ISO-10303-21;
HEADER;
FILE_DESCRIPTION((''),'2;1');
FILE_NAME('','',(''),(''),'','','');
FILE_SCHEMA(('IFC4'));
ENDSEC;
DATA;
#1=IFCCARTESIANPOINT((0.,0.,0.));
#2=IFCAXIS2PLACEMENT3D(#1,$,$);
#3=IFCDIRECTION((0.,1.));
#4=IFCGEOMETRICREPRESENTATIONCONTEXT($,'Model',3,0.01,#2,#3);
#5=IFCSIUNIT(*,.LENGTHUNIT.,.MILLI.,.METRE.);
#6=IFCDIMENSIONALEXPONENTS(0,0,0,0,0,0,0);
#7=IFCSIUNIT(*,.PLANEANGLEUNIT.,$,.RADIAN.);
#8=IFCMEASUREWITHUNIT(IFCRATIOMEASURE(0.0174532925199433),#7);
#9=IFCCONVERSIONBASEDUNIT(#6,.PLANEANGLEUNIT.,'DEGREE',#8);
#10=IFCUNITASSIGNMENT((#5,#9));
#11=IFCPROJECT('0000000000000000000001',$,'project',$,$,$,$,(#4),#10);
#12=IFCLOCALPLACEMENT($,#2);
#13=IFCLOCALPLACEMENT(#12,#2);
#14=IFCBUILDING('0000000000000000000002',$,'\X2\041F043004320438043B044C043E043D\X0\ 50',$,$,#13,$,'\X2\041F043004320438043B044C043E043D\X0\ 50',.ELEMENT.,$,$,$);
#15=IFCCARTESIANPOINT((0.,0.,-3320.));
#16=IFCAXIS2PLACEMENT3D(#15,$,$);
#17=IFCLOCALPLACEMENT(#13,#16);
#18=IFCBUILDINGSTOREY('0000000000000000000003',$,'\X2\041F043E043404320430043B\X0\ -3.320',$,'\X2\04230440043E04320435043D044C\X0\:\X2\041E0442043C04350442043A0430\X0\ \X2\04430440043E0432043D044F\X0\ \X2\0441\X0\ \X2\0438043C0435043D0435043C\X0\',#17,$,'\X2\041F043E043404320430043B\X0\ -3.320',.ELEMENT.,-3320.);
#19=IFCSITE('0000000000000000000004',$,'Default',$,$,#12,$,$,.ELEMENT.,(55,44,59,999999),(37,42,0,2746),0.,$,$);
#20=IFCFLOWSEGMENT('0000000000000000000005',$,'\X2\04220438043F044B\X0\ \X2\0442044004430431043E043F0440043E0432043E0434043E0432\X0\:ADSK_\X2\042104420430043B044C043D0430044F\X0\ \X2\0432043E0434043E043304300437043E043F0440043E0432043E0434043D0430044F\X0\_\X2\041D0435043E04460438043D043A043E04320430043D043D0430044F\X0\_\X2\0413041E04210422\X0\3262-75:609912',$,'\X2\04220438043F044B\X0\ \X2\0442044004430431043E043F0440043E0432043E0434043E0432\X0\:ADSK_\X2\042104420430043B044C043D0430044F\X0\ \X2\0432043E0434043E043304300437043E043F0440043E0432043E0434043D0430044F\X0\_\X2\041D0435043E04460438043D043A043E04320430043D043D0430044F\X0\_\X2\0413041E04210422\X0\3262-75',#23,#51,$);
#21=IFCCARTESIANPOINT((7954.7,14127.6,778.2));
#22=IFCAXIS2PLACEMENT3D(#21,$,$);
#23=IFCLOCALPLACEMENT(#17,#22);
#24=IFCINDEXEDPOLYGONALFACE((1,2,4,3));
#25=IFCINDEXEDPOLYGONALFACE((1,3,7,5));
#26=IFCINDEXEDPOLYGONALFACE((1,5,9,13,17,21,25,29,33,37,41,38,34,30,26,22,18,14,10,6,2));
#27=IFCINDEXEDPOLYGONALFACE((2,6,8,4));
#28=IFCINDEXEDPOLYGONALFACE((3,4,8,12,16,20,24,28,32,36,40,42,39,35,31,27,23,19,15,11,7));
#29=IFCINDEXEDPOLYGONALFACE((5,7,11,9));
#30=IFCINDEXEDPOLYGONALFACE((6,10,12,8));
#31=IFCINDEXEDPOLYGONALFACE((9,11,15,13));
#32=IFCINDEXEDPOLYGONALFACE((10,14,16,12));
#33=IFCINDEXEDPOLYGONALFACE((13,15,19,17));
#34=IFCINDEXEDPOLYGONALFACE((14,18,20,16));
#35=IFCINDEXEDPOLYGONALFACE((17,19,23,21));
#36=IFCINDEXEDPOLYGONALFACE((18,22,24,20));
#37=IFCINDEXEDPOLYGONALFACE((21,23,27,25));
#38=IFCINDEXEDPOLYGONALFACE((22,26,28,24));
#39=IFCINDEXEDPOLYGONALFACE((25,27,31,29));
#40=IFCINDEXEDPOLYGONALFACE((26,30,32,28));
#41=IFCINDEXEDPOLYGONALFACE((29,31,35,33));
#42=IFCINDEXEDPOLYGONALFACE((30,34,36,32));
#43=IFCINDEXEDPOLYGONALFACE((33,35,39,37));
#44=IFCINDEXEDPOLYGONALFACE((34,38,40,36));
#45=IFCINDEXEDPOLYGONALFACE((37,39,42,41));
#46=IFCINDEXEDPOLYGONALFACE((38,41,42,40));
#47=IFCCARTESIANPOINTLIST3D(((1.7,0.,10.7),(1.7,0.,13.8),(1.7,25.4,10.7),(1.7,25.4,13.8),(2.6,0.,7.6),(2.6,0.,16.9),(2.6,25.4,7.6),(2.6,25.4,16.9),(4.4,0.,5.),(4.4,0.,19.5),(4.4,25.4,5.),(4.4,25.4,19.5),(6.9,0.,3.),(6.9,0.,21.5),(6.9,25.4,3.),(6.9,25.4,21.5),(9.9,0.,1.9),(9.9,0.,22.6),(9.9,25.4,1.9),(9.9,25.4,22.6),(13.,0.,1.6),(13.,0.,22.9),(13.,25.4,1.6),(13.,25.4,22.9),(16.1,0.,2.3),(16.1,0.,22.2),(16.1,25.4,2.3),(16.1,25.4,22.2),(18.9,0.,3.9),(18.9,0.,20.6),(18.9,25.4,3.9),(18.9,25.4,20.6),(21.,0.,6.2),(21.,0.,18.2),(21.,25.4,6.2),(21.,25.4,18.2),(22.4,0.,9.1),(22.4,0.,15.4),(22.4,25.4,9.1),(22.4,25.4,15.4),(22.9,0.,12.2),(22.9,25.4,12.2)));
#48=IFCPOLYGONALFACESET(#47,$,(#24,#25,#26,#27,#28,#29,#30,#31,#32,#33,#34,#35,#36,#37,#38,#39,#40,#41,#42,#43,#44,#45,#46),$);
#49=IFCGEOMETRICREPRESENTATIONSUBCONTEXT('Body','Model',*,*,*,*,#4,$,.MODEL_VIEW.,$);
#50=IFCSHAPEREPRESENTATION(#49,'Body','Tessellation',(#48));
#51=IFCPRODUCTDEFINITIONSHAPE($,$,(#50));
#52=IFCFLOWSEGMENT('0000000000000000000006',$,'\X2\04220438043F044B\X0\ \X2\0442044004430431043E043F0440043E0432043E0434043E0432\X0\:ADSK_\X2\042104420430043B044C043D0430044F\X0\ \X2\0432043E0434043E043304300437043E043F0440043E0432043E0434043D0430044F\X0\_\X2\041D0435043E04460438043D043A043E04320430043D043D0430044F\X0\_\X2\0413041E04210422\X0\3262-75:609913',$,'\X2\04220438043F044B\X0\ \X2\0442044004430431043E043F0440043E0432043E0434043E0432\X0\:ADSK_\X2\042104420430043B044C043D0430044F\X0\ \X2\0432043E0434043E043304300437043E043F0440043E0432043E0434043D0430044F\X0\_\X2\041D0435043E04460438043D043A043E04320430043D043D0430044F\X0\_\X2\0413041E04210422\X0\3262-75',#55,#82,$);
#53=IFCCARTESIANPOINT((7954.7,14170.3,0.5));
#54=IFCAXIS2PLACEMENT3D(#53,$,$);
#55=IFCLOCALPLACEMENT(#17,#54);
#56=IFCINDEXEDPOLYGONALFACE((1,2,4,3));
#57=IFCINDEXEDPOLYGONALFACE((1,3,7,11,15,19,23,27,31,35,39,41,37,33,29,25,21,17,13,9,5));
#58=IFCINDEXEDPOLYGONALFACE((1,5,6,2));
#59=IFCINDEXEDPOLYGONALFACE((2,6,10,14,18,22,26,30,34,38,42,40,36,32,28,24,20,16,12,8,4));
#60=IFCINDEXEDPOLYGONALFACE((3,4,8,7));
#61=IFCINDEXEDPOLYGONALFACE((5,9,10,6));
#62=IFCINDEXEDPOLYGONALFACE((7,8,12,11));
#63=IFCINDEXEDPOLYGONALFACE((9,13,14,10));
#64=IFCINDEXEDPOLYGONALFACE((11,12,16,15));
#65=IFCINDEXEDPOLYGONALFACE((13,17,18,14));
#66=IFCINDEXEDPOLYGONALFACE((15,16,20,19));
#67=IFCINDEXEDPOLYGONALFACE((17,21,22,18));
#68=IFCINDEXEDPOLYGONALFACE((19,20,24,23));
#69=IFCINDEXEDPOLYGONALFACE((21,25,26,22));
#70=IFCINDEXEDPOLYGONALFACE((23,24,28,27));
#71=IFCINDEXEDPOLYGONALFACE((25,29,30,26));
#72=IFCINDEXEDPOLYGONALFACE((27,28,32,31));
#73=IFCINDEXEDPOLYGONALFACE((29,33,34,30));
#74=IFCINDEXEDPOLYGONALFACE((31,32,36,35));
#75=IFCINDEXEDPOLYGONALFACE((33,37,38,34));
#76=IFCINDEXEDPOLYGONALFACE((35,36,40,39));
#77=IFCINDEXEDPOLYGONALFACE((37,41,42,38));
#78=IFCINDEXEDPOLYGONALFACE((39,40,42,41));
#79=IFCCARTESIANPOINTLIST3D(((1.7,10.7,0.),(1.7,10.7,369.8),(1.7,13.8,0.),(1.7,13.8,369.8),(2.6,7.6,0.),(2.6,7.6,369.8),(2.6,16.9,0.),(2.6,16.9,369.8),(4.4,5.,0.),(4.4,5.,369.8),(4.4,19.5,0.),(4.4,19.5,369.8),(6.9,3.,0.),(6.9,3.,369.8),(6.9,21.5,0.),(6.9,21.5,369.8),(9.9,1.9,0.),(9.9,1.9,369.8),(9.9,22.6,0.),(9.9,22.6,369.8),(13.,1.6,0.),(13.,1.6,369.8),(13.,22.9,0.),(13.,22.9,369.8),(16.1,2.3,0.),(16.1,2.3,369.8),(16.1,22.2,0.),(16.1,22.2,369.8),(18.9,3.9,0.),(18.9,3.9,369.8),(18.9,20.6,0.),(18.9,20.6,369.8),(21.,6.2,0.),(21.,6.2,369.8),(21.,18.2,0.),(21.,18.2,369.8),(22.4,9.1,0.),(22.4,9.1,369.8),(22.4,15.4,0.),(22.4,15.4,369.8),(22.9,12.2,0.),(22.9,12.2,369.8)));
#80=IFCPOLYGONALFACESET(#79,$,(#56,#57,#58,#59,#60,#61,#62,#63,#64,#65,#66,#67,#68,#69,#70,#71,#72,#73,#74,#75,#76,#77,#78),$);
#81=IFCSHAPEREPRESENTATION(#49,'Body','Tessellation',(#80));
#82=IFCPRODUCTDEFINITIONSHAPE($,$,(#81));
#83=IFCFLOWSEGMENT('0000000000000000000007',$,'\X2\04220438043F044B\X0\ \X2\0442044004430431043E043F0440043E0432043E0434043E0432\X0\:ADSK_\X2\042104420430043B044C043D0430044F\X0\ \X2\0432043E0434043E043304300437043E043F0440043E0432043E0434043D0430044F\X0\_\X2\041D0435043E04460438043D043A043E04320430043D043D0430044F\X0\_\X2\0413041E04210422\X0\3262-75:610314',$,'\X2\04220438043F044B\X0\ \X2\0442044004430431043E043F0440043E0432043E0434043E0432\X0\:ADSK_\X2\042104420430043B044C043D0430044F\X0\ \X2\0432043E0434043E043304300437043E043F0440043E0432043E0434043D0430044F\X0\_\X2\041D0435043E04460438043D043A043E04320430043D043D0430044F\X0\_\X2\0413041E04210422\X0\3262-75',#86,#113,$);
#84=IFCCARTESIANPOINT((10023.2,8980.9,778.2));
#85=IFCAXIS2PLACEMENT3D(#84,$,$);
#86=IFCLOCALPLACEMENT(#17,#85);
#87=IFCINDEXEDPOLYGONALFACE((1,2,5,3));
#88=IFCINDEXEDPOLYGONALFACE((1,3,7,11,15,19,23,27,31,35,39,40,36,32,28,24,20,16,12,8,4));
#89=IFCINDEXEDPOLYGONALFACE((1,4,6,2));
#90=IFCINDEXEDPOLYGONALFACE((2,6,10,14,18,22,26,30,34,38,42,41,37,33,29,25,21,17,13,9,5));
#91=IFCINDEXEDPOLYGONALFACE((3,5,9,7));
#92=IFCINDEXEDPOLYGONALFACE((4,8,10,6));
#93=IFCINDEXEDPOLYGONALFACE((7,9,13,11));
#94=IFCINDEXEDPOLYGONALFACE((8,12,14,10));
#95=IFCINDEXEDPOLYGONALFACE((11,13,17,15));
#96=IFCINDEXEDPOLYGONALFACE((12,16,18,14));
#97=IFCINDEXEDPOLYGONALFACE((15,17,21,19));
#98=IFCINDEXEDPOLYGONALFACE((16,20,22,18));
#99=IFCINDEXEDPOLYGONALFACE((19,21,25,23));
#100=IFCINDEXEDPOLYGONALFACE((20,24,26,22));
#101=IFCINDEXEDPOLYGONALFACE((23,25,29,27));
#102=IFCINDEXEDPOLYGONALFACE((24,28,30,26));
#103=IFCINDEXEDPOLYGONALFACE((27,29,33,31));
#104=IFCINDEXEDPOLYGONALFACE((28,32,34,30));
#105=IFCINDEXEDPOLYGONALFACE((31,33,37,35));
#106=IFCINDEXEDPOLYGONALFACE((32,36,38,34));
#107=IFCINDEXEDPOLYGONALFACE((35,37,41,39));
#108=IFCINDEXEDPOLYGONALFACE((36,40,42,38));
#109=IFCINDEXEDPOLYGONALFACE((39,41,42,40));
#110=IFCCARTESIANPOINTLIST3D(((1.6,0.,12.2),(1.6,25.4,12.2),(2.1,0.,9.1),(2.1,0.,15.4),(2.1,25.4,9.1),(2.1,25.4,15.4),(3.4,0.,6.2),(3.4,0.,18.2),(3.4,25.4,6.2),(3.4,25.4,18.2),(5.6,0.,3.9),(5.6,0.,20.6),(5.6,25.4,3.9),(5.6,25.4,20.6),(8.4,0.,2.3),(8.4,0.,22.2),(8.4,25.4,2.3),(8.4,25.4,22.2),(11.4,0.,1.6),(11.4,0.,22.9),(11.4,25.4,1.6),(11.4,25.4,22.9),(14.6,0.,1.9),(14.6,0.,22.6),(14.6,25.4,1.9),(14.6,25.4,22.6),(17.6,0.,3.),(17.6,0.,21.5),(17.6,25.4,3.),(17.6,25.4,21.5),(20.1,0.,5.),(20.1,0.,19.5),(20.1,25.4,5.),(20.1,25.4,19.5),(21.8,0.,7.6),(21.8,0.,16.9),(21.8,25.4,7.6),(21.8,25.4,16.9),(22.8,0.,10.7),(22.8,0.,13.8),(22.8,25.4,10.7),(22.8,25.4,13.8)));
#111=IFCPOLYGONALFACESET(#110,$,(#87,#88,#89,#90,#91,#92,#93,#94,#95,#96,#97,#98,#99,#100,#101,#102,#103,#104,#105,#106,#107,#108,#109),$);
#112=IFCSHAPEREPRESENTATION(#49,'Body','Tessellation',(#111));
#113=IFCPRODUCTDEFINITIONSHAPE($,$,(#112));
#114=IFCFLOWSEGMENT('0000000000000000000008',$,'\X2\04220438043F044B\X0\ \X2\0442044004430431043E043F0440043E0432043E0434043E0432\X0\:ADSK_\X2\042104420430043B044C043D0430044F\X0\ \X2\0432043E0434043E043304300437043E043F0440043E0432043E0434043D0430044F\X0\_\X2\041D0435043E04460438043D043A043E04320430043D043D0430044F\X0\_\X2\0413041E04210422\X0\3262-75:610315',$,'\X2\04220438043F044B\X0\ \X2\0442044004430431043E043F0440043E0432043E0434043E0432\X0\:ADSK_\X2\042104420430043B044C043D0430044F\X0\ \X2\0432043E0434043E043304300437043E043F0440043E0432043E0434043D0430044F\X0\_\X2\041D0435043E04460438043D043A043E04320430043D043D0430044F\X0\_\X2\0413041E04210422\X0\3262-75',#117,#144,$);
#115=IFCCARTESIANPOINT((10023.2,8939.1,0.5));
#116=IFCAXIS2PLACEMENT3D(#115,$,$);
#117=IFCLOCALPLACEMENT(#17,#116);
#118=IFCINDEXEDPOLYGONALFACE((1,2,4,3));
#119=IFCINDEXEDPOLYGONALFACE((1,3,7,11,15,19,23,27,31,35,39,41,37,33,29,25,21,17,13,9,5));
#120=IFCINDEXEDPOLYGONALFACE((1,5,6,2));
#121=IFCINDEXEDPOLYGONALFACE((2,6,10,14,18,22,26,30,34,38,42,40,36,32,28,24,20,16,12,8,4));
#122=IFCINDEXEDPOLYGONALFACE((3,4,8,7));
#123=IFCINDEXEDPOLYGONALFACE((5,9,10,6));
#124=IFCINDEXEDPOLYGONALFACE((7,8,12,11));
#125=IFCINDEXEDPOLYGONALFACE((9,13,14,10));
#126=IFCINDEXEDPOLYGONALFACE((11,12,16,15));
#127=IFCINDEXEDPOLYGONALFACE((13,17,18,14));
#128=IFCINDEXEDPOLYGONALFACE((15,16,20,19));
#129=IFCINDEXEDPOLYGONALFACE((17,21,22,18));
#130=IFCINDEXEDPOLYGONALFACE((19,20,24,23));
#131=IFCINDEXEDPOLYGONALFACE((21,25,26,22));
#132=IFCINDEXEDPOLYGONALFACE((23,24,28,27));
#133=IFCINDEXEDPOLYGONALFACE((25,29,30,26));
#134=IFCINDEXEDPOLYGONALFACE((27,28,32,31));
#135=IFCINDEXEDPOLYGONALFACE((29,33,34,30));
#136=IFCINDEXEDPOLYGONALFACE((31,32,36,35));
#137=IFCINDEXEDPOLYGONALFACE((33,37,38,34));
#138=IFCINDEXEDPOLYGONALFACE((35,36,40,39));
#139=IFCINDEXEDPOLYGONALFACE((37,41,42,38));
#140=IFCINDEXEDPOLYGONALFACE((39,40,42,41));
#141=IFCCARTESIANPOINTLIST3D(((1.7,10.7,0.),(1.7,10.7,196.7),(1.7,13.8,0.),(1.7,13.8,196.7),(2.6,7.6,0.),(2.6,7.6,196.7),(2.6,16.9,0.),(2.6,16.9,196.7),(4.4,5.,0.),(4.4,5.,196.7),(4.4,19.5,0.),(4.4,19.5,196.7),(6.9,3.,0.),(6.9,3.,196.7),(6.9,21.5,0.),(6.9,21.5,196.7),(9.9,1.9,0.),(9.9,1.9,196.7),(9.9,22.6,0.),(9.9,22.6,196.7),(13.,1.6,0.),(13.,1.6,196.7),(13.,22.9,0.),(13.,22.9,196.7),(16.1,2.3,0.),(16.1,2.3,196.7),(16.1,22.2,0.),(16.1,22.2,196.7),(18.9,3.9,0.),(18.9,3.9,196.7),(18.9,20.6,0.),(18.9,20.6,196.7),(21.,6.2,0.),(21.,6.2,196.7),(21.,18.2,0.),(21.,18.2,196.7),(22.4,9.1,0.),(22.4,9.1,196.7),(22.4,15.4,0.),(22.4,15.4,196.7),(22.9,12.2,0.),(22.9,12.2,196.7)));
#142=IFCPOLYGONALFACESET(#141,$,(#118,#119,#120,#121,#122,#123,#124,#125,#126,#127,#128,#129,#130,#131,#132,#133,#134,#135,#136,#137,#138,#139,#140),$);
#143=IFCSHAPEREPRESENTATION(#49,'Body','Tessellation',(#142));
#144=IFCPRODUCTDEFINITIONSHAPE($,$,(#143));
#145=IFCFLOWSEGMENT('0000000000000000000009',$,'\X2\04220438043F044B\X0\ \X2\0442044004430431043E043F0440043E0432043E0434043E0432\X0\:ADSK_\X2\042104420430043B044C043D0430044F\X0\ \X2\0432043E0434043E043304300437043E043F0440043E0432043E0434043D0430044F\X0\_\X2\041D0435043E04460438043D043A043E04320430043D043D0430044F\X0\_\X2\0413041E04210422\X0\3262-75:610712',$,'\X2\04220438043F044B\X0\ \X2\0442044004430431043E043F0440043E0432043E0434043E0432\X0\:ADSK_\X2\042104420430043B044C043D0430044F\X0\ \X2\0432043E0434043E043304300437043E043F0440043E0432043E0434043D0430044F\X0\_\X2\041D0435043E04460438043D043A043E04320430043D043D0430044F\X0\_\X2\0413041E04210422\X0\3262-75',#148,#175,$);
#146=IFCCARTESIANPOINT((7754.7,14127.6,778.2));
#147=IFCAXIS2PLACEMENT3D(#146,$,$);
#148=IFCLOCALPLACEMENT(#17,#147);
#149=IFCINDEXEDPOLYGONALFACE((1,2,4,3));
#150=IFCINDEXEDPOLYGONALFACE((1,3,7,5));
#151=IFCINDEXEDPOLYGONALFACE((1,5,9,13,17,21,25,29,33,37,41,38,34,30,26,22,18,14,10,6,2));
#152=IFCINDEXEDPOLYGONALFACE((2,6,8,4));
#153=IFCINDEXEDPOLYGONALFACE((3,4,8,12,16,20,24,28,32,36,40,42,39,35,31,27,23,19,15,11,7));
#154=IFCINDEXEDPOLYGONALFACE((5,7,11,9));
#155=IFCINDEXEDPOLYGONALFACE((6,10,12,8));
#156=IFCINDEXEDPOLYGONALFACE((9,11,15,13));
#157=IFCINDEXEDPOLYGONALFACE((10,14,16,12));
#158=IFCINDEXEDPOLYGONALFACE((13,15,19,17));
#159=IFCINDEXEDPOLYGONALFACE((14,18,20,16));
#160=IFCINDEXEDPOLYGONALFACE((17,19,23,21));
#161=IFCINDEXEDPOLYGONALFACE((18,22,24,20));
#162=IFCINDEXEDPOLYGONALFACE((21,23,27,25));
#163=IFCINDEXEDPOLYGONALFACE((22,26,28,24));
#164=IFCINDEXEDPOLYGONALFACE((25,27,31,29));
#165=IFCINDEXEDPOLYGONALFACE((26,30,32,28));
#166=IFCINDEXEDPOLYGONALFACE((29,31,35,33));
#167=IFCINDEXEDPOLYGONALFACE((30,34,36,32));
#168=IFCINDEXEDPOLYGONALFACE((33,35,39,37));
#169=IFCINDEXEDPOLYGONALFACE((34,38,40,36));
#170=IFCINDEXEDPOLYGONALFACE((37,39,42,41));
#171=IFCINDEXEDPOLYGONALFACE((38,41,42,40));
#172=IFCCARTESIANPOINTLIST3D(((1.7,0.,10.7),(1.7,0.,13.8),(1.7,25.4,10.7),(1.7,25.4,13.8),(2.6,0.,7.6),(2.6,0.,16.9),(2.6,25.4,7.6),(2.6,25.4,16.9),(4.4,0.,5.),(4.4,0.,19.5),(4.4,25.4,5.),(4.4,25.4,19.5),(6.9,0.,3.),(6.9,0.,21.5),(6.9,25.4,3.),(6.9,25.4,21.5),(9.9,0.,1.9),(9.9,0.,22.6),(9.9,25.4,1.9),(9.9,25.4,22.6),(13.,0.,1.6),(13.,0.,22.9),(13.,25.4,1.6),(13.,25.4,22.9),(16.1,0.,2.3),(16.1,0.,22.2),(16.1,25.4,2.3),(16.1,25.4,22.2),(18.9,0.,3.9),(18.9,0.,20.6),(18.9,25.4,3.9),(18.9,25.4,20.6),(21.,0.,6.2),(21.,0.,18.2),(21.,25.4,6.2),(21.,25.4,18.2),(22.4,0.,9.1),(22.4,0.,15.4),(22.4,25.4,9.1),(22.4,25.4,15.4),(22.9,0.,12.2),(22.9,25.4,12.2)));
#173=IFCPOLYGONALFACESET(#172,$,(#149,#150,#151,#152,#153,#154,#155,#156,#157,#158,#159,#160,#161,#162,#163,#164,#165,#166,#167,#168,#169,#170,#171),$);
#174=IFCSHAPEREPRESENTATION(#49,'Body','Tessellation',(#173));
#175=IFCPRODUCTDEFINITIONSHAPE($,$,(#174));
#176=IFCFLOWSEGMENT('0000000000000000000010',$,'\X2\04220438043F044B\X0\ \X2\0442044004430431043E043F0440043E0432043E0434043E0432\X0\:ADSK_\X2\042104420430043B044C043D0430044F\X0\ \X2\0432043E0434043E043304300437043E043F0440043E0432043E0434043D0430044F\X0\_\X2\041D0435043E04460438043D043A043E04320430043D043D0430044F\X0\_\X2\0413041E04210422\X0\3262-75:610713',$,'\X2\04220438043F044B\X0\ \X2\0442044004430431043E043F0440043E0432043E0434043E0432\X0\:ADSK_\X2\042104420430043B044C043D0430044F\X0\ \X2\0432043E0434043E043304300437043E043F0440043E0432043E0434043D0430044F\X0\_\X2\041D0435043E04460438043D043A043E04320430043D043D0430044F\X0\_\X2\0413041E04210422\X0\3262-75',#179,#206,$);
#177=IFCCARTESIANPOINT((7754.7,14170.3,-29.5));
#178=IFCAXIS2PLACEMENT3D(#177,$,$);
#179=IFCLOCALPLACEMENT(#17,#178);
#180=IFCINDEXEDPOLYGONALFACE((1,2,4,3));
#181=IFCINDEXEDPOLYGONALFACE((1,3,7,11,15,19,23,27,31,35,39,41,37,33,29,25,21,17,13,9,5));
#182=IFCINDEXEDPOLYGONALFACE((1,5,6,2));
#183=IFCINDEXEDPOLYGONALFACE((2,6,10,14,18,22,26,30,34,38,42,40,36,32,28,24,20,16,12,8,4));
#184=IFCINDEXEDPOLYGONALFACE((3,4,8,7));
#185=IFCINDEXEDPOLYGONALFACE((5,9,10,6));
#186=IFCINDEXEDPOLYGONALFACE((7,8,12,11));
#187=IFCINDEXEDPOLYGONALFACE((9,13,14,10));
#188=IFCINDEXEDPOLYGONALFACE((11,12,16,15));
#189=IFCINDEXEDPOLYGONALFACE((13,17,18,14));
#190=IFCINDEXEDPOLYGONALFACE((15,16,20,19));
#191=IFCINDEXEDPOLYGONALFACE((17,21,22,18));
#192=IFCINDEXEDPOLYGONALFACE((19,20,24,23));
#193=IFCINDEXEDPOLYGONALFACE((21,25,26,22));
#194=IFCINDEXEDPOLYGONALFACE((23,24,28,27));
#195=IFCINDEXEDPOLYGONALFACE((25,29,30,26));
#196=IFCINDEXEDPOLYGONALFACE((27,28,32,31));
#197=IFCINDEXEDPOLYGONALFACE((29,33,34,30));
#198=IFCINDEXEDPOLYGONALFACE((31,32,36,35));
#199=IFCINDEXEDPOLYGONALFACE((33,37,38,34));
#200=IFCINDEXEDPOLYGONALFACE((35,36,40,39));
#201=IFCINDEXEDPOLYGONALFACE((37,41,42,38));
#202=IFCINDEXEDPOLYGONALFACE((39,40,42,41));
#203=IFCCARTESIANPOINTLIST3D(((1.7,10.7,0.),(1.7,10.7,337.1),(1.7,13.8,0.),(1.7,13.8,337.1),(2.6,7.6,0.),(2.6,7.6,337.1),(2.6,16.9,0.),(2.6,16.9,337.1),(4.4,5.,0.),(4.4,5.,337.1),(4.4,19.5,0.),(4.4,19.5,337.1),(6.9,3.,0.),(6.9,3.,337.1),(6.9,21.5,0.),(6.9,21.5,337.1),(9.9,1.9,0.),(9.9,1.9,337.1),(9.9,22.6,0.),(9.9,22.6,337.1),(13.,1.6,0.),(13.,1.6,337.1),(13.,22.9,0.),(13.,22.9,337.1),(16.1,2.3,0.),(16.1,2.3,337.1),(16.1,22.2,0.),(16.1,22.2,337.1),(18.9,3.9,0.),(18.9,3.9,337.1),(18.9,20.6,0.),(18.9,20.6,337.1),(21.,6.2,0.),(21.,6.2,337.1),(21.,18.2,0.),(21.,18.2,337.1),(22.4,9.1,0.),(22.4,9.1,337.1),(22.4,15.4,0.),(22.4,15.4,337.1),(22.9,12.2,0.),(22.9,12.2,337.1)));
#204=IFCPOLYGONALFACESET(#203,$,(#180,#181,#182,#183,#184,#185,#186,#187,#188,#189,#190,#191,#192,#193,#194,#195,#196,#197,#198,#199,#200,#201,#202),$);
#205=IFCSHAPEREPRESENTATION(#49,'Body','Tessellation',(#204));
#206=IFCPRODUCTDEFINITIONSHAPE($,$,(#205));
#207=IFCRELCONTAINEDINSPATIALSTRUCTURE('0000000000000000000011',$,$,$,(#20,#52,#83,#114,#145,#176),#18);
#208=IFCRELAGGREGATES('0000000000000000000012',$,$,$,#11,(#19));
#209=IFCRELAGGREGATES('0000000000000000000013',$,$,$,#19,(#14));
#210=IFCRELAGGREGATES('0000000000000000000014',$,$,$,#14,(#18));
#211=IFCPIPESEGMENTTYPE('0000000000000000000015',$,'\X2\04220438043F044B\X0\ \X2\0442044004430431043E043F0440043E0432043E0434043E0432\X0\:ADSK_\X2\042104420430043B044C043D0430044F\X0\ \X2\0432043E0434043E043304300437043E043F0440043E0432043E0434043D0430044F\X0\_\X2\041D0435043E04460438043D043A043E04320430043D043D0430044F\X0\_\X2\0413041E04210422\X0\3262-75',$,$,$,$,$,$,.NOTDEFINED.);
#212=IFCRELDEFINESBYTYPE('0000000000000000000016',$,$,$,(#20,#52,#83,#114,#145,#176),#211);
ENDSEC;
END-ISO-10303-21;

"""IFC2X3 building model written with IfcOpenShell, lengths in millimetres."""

from ifc_helpers import new_model, entity, si_unit, converted_unit, direction, frame, frame_2d, origin, origin_2d_with_axis, place, context, subcontext, project, spatial, circle, extrude, type_object, element, save


model = new_model("IFC2X3")

# Units and contexts
model_context = context("Model", 3, precision=0.01, world=origin(), true_north=direction((0.0, 1.0)))
body_context = subcontext(model_context, "Body", "Model", "MODEL_VIEW")
ifc_project = project(units=[si_unit("LENGTHUNIT", "METRE", prefix="MILLI"), converted_unit("PLANEANGLEUNIT", "DEGREE", entity("IfcRatioMeasure", 0.0174532925199433), si_unit("PLANEANGLEUNIT", "RADIAN"), dimensions=[0, 0, 0, 0, 0, 0, 0])], contexts=[model_context])

# Site, building, storey
site_placement = place(None, origin())
site = spatial("IfcSite", under=ifc_project, at=site_placement, Name="Default", CompositionType="ELEMENT", RefLatitude=(55, 44, 59, 999999), RefLongitude=(37, 42, 0, 2746), RefElevation=0.0)
building_placement = place(site_placement, origin())
building = spatial("IfcBuilding", under=site, at=building_placement, Name="Павильон 50", LongName="Павильон 50", CompositionType="ELEMENT")
storey_placement = place(building_placement, frame((0.0, 0.0, -3320.0)))
storey = spatial("IfcBuildingStorey", under=building, at=storey_placement, Name="Подвал -3.320", ObjectType="Уровень:Отметка уровня с именем", LongName="Подвал -3.320", CompositionType="ELEMENT", Elevation=-3320.0)

# Flow segments
pipe_segment_type = type_object("IfcPipeSegmentType", Name="Типы трубопроводов:ADSK_Стальная водогазопроводная_Неоцинкованная_ГОСТ3262-75", PredefinedType="NOTDEFINED")
flow_segment_1_placement = place(storey_placement, frame((7954.7, 14127.6, 778.2)))
element("IfcFlowSegment", 1, at=flow_segment_1_placement, inside=storey, type_object=pipe_segment_type, Name="Типы трубопроводов:ADSK_Стальная водогазопроводная_Неоцинкованная_ГОСТ3262-75:609912", ObjectType="Типы трубопроводов:ADSK_Стальная водогазопроводная_Неоцинкованная_ГОСТ3262-75", context=body_context, shape_type="SweptSolid", body=[
    extrude(circle(Radius=10.7, at=origin_2d_with_axis()), frame((12.2, 0.0, 12.2), z_axis=(0.0, 1.0, 0.0), x_axis=(1.0, 0.0, 0.0)), (0.0, 0.0, 1.0), 25.4),
])
flow_segment_2_placement = place(storey_placement, frame((7954.7, 14170.3, 0.5)))
element("IfcFlowSegment", 2, at=flow_segment_2_placement, inside=storey, type_object=pipe_segment_type, Name="Типы трубопроводов:ADSK_Стальная водогазопроводная_Неоцинкованная_ГОСТ3262-75:609913", ObjectType="Типы трубопроводов:ADSK_Стальная водогазопроводная_Неоцинкованная_ГОСТ3262-75", context=body_context, shape_type="SweptSolid", body=[
    extrude(circle(Radius=10.7, at=frame_2d((0.0, 0.0), x_axis=(1.0, 0.0))), frame((12.2, 12.2, 0.0)), (0.0, 0.0, 1.0), 369.8),
])
flow_segment_3_placement = place(storey_placement, frame((10023.2, 8980.9, 778.2)))
element("IfcFlowSegment", 3, at=flow_segment_3_placement, inside=storey, type_object=pipe_segment_type, Name="Типы трубопроводов:ADSK_Стальная водогазопроводная_Неоцинкованная_ГОСТ3262-75:610314", ObjectType="Типы трубопроводов:ADSK_Стальная водогазопроводная_Неоцинкованная_ГОСТ3262-75", context=body_context, shape_type="SweptSolid", body=[
    extrude(circle(Radius=10.7, at=frame_2d((0.0, 0.0), x_axis=(1.0, 0.0))), frame((12.2, 0.0, 12.2), z_axis=(0.0, 1.0, 0.0), x_axis=(-1.0, 0.0, 0.0)), (0.0, 0.0, 1.0), 25.4),
])
flow_segment_4_placement = place(storey_placement, frame((10023.2, 8939.1, 0.5)))
element("IfcFlowSegment", 4, at=flow_segment_4_placement, inside=storey, type_object=pipe_segment_type, Name="Типы трубопроводов:ADSK_Стальная водогазопроводная_Неоцинкованная_ГОСТ3262-75:610315", ObjectType="Типы трубопроводов:ADSK_Стальная водогазопроводная_Неоцинкованная_ГОСТ3262-75", context=body_context, shape_type="SweptSolid", body=[
    extrude(circle(Radius=10.7, at=origin_2d_with_axis()), frame((12.2, 12.2, 0.0)), (0.0, 0.0, 1.0), 196.7),
])
flow_segment_5_placement = place(storey_placement, frame((7754.7, 14127.6, 778.2)))
element("IfcFlowSegment", 5, at=flow_segment_5_placement, inside=storey, type_object=pipe_segment_type, Name="Типы трубопроводов:ADSK_Стальная водогазопроводная_Неоцинкованная_ГОСТ3262-75:610712", ObjectType="Типы трубопроводов:ADSK_Стальная водогазопроводная_Неоцинкованная_ГОСТ3262-75", context=body_context, shape_type="SweptSolid", body=[
    extrude(circle(Radius=10.7, at=origin_2d_with_axis()), frame((12.2, 0.0, 12.2), z_axis=(0.0, 1.0, 0.0), x_axis=(1.0, 0.0, 0.0)), (0.0, 0.0, 1.0), 25.4),
])
flow_segment_6_placement = place(storey_placement, frame((7754.7, 14170.3, -29.5)))
element("IfcFlowSegment", 6, at=flow_segment_6_placement, inside=storey, type_object=pipe_segment_type, Name="Типы трубопроводов:ADSK_Стальная водогазопроводная_Неоцинкованная_ГОСТ3262-75:610713", ObjectType="Типы трубопроводов:ADSK_Стальная водогазопроводная_Неоцинкованная_ГОСТ3262-75", context=body_context, shape_type="SweptSolid", body=[
    extrude(circle(Radius=10.7, at=frame_2d((0.0, 0.0), x_axis=(1.0, 0.0))), frame((12.2, 12.2, 0.0)), (0.0, 0.0, 1.0), 337.1),
])

save(model, "model.ifc")
